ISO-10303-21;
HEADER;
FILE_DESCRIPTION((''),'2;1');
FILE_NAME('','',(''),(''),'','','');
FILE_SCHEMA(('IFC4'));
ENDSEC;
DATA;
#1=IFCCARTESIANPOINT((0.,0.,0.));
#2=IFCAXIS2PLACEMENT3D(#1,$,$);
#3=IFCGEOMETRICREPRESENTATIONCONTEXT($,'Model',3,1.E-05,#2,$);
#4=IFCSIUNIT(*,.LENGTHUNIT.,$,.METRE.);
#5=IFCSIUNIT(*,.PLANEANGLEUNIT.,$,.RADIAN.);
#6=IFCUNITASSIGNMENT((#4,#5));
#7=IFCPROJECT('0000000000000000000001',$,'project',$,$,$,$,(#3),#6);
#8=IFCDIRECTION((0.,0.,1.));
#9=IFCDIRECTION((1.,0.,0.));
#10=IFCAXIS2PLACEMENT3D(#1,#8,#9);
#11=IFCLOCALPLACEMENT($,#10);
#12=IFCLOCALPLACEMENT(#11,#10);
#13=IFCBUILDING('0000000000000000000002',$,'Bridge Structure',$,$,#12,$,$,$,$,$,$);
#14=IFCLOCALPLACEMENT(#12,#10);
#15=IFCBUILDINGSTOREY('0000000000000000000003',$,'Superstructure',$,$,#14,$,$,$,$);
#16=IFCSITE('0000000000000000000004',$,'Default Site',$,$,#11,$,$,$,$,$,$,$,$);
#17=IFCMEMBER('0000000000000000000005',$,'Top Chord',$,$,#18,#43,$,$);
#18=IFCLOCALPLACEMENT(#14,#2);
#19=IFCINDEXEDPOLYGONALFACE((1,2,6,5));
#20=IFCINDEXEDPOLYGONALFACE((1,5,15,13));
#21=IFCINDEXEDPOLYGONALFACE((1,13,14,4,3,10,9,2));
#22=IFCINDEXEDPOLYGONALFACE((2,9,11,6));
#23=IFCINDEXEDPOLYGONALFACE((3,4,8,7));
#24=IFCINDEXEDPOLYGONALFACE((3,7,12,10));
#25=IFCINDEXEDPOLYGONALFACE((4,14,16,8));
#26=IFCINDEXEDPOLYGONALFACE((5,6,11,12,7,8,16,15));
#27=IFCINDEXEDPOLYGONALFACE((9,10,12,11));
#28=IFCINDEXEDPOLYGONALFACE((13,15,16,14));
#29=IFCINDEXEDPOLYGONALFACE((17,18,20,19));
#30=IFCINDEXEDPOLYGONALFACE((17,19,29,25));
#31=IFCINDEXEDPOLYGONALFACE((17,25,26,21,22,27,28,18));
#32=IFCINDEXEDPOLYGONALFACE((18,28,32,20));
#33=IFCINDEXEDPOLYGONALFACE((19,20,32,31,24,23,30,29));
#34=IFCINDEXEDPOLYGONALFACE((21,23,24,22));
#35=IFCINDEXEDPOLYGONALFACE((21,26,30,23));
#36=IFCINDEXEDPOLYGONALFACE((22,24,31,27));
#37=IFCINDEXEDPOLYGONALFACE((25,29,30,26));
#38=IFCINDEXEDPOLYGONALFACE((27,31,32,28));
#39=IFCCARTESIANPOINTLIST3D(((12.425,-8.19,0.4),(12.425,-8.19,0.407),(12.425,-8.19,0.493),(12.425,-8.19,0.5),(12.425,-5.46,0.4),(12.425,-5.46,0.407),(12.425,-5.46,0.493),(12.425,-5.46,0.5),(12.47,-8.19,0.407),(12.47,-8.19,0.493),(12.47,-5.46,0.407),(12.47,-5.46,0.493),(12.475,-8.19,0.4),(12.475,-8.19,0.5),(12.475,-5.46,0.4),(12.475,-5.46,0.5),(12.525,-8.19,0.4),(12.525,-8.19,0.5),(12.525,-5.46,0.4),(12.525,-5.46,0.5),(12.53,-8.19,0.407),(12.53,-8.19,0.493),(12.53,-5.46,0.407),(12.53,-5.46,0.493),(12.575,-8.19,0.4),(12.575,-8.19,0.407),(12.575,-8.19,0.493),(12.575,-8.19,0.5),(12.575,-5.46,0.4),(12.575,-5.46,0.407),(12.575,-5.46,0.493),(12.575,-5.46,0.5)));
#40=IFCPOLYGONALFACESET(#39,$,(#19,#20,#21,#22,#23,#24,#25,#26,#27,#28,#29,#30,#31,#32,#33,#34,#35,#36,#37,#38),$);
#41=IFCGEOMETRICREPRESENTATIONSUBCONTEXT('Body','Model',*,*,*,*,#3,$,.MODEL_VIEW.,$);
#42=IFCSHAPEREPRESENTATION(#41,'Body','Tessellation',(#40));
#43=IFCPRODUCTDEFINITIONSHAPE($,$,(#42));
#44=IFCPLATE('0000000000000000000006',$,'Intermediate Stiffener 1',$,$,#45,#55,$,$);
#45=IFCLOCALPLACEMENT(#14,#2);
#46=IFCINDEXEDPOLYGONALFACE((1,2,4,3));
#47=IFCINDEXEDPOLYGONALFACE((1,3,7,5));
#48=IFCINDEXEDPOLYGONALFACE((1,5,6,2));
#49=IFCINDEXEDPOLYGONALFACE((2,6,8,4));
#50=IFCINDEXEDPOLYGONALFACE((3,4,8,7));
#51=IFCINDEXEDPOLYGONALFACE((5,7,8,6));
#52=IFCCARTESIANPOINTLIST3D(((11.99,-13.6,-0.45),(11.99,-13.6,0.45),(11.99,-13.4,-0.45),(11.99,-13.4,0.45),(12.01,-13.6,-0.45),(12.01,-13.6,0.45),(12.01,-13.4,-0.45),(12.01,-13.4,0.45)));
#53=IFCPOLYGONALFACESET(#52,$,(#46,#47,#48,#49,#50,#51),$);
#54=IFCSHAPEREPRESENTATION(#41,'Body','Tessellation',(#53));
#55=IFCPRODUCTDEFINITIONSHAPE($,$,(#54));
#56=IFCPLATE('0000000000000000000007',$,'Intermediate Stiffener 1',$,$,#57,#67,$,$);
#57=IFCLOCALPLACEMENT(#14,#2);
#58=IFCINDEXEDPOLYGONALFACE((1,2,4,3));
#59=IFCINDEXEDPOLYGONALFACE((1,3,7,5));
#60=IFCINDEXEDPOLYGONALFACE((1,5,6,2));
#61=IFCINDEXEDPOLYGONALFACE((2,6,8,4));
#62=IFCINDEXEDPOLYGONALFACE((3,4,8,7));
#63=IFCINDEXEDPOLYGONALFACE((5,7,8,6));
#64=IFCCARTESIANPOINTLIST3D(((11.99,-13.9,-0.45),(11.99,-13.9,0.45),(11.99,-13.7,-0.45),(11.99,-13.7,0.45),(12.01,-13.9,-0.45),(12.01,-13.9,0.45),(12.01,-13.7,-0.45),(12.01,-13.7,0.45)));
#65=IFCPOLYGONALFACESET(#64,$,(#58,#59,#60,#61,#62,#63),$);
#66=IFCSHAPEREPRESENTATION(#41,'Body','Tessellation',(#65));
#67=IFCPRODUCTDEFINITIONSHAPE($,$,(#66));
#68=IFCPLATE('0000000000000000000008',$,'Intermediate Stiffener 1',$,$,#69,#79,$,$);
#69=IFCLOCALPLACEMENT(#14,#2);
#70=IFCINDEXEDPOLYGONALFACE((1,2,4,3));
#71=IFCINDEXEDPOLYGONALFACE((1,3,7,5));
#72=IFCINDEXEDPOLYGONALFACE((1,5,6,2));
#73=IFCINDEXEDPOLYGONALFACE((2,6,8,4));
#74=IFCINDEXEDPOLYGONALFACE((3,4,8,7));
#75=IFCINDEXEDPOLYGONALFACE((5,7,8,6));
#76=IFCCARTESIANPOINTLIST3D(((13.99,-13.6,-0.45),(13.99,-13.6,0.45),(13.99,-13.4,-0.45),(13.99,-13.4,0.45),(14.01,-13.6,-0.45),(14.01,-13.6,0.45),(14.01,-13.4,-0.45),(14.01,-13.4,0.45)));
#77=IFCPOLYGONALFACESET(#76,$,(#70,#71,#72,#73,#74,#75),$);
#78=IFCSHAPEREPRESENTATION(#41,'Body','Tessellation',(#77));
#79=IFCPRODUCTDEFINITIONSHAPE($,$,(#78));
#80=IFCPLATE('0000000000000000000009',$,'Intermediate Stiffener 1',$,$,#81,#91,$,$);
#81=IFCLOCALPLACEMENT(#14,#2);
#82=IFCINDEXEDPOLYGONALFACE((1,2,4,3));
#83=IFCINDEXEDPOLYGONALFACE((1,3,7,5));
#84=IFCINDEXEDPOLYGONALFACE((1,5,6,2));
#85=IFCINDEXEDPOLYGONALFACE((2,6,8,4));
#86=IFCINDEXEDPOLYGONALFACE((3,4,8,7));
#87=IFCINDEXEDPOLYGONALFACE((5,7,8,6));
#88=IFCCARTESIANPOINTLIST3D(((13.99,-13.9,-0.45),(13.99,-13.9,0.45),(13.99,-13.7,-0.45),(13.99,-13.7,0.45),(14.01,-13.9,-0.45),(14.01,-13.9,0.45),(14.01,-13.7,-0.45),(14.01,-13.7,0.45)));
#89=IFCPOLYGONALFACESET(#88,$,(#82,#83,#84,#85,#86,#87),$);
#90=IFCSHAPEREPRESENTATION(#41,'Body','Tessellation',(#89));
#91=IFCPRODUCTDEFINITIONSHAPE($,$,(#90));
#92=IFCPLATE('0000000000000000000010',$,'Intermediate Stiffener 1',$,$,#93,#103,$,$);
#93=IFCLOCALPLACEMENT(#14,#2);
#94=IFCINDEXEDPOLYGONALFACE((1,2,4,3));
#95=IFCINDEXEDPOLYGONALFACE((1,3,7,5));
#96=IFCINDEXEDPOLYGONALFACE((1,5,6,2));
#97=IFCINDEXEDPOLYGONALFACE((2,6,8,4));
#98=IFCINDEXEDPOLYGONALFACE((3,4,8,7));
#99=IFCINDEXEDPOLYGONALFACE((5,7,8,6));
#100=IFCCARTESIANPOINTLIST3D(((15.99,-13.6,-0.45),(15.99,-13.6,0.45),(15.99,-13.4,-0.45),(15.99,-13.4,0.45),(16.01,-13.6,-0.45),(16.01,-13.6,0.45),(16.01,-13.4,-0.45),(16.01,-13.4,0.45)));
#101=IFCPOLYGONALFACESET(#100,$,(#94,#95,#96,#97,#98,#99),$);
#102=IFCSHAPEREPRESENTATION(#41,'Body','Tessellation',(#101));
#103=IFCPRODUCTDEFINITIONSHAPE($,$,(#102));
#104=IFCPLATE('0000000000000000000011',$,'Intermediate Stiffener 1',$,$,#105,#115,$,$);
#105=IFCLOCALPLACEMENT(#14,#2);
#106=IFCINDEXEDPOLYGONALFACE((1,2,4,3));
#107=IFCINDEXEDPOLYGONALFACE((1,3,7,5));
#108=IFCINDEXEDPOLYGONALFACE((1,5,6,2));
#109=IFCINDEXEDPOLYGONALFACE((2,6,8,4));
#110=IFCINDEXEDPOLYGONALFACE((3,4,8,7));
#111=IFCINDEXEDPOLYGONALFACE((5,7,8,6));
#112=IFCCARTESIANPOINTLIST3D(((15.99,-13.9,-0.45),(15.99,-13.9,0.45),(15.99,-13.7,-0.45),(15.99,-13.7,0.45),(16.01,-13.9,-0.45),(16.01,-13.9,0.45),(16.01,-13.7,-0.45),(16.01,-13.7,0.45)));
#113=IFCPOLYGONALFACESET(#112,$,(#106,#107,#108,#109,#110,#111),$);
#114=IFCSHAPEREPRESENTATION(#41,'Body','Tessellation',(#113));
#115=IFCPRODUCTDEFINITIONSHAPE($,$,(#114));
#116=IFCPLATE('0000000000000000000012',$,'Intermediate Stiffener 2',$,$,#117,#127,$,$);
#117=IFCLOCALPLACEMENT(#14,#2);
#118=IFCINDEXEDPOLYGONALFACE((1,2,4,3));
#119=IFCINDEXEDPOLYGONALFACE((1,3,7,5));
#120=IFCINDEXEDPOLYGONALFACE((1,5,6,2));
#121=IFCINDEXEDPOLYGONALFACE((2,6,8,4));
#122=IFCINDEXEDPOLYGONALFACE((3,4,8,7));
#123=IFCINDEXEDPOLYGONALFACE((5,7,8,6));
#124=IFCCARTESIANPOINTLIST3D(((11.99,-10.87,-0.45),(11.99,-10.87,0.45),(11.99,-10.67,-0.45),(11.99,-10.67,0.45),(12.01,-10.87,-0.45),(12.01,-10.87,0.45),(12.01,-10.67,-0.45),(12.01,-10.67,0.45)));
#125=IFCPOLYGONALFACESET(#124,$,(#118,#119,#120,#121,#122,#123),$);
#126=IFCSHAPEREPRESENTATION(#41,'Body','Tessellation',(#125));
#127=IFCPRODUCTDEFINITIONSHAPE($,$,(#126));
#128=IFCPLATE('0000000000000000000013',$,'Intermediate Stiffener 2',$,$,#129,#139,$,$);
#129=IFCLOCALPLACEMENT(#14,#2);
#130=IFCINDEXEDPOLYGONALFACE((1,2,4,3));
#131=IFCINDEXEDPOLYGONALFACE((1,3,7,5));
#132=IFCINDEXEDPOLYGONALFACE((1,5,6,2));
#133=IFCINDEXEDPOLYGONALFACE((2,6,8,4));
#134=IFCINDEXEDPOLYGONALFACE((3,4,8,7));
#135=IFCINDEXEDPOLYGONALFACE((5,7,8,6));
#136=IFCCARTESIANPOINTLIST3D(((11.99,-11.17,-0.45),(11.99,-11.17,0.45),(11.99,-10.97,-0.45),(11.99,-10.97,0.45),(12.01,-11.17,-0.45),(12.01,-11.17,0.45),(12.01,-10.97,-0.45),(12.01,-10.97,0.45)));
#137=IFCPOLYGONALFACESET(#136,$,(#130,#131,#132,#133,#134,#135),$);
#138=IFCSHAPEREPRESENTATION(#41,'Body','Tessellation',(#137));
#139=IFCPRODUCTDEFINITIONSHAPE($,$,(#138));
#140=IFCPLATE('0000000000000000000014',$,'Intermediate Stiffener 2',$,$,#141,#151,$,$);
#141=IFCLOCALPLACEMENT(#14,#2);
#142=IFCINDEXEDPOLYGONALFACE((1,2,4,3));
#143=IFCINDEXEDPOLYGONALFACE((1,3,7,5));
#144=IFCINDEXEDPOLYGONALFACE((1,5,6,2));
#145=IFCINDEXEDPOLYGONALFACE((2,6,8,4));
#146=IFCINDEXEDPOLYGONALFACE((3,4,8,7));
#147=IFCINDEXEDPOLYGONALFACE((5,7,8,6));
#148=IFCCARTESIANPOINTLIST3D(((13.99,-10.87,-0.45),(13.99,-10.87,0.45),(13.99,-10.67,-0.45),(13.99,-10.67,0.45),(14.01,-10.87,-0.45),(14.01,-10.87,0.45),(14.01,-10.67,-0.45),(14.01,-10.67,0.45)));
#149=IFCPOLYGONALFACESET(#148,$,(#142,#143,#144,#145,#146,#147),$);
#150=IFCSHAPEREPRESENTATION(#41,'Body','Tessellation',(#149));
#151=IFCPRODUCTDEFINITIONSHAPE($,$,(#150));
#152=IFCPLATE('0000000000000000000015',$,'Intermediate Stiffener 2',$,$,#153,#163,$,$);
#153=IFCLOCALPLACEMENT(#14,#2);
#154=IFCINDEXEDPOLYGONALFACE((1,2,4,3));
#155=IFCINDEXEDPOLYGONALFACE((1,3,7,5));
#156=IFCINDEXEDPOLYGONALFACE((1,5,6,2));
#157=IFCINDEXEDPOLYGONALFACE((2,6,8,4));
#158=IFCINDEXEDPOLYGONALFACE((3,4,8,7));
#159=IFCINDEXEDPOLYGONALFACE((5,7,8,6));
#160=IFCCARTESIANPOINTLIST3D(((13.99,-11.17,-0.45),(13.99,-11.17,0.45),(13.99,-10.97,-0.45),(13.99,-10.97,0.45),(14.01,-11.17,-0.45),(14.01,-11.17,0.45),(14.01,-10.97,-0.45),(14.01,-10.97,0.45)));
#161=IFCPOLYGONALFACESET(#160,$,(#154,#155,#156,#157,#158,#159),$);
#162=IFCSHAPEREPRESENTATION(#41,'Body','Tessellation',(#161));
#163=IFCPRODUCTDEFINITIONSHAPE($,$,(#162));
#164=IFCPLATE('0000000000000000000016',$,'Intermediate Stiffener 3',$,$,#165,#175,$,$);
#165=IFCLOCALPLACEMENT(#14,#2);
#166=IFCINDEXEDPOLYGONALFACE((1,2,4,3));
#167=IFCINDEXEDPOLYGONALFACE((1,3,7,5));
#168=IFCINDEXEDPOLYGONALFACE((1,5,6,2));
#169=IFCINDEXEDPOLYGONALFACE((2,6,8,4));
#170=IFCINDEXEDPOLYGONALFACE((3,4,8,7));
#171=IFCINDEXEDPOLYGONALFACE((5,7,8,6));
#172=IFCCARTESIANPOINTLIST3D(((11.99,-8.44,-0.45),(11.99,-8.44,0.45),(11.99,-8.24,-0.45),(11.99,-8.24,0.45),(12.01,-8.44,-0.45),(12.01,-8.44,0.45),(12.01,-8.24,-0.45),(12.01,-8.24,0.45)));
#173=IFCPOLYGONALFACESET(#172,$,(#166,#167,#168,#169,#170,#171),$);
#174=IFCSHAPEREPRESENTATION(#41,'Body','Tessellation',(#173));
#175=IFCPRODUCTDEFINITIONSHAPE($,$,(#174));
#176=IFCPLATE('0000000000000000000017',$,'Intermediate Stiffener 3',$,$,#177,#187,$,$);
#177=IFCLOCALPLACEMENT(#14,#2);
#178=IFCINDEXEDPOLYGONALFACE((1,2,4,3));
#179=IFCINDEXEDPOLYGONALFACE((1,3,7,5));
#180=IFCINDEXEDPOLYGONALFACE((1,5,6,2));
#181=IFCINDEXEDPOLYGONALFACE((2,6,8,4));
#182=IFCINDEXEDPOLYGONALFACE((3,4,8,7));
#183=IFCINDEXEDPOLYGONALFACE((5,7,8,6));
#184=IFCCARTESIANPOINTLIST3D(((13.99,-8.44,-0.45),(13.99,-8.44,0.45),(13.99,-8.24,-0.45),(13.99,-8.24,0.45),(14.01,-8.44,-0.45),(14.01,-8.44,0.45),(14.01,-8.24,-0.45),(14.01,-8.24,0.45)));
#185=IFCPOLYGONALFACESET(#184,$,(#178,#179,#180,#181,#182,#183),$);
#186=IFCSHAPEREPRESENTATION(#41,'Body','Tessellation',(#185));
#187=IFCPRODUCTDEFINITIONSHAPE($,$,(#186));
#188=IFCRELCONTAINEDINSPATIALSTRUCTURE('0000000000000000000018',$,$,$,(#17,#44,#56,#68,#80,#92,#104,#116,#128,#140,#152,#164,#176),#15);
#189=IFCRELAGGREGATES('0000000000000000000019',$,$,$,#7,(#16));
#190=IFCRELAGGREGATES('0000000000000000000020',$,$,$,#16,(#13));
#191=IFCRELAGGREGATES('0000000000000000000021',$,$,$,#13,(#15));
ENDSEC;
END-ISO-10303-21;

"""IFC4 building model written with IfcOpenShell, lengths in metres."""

from ifc_helpers import new_model, si_unit, frame, origin, origin_with_axes, origin_2d_with_axis, place, context, subcontext, project, spatial, polyline, rectangle, outline, composite_profile, extrude, element, save


model = new_model("IFC4")

# Units and contexts
model_context = context("Model", 3, precision=1e-05, world=origin())
body_context = subcontext(model_context, "Body", "Model", "MODEL_VIEW")
ifc_project = project(units=[si_unit("LENGTHUNIT", "METRE"), si_unit("PLANEANGLEUNIT", "RADIAN")], contexts=[model_context])

# Site, building, storey
site_placement = place(None, origin_with_axes())
site = spatial("IfcSite", under=ifc_project, at=site_placement, Name="Default Site")
building_placement = place(site_placement, origin_with_axes())
building = spatial("IfcBuilding", under=site, at=building_placement, Name="Bridge Structure")
storey_placement = place(building_placement, origin_with_axes())
storey = spatial("IfcBuildingStorey", under=building, at=storey_placement, Name="Superstructure")

# Member
member_1_placement = place(storey_placement, frame((12.5, -8.19, 0.45), z_axis=(0.0, 1.0, 0.0), x_axis=(-1.0, 0.0, 0.0)))
element("IfcMember", 1, at=member_1_placement, inside=storey, Name="Top Chord", context=body_context, shape_type="SweptSolid", body=[
    extrude(composite_profile([outline(polyline([(-0.025, -0.05), (-0.025, 0.05), (-0.075, 0.05), (-0.075, 0.043), (-0.03, 0.043), (-0.03, -0.043), (-0.075, -0.043), (-0.075, -0.05), (-0.025, -0.05)])), outline(polyline([(0.025, -0.05), (0.075, -0.05), (0.075, -0.043), (0.03, -0.043), (0.03, 0.043), (0.075, 0.043), (0.075, 0.05), (0.025, 0.05), (0.025, -0.05)]))]), origin_with_axes(), (0.0, 0.0, 1.0), 2.73),
])

# Plates
for number, where, z_axis, x_axis, name in (
    (2, (12.0, -13.5, -0.45), (0.0, 0.0, 1.0), (1.0, 0.0, 0.0), "Intermediate Stiffener 1"),
    (3, (12.0, -13.8, -0.45), (0.0, 0.0, 1.0), (1.0, 0.0, 0.0), "Intermediate Stiffener 1"),
    (4, (14.0, -13.5, -0.45), (0.0, 0.0, 1.0), (1.0, 0.0, 0.0), "Intermediate Stiffener 1"),
    (5, (14.0, -13.8, -0.45), (0.0, 0.0, 1.0), (1.0, 0.0, 0.0), "Intermediate Stiffener 1"),
    (6, (16.0, -13.5, -0.45), (0.0, 0.0, 1.0), (1.0, 0.0, 0.0), "Intermediate Stiffener 1"),
    (7, (16.0, -13.8, -0.45), (0.0, 0.0, 1.0), (1.0, 0.0, 0.0), "Intermediate Stiffener 1"),
    (8, (12.0, -10.77, -0.45), (0.0, 0.0, 1.0), (1.0, 0.0, 0.0), "Intermediate Stiffener 2"),
    (9, (12.0, -11.07, -0.45), (0.0, 0.0, 1.0), (1.0, 0.0, 0.0), "Intermediate Stiffener 2"),
    (10, (14.0, -10.77, -0.45), (0.0, 0.0, 1.0), (1.0, 0.0, 0.0), "Intermediate Stiffener 2"),
    (11, (14.0, -11.07, -0.45), (0.0, 0.0, 1.0), (1.0, 0.0, 0.0), "Intermediate Stiffener 2"),
    (12, (12.0, -8.34, -0.45), (0.0, 0.0, 1.0), (1.0, 0.0, 0.0), "Intermediate Stiffener 3"),
    (13, (14.0, -8.34, -0.45), (0.0, 0.0, 1.0), (1.0, 0.0, 0.0), "Intermediate Stiffener 3"),
):
    element("IfcPlate", number, at=place(storey_placement, frame(where, z_axis=z_axis, x_axis=x_axis)), inside=storey, Name=name, context=body_context, shape_type="SweptSolid", body=[
        extrude(rectangle(XDim=0.02, YDim=0.2, at=origin_2d_with_axis()), origin_with_axes(), (0.0, 0.0, 1.0), 0.9),
    ])

save(model, "model.ifc")
